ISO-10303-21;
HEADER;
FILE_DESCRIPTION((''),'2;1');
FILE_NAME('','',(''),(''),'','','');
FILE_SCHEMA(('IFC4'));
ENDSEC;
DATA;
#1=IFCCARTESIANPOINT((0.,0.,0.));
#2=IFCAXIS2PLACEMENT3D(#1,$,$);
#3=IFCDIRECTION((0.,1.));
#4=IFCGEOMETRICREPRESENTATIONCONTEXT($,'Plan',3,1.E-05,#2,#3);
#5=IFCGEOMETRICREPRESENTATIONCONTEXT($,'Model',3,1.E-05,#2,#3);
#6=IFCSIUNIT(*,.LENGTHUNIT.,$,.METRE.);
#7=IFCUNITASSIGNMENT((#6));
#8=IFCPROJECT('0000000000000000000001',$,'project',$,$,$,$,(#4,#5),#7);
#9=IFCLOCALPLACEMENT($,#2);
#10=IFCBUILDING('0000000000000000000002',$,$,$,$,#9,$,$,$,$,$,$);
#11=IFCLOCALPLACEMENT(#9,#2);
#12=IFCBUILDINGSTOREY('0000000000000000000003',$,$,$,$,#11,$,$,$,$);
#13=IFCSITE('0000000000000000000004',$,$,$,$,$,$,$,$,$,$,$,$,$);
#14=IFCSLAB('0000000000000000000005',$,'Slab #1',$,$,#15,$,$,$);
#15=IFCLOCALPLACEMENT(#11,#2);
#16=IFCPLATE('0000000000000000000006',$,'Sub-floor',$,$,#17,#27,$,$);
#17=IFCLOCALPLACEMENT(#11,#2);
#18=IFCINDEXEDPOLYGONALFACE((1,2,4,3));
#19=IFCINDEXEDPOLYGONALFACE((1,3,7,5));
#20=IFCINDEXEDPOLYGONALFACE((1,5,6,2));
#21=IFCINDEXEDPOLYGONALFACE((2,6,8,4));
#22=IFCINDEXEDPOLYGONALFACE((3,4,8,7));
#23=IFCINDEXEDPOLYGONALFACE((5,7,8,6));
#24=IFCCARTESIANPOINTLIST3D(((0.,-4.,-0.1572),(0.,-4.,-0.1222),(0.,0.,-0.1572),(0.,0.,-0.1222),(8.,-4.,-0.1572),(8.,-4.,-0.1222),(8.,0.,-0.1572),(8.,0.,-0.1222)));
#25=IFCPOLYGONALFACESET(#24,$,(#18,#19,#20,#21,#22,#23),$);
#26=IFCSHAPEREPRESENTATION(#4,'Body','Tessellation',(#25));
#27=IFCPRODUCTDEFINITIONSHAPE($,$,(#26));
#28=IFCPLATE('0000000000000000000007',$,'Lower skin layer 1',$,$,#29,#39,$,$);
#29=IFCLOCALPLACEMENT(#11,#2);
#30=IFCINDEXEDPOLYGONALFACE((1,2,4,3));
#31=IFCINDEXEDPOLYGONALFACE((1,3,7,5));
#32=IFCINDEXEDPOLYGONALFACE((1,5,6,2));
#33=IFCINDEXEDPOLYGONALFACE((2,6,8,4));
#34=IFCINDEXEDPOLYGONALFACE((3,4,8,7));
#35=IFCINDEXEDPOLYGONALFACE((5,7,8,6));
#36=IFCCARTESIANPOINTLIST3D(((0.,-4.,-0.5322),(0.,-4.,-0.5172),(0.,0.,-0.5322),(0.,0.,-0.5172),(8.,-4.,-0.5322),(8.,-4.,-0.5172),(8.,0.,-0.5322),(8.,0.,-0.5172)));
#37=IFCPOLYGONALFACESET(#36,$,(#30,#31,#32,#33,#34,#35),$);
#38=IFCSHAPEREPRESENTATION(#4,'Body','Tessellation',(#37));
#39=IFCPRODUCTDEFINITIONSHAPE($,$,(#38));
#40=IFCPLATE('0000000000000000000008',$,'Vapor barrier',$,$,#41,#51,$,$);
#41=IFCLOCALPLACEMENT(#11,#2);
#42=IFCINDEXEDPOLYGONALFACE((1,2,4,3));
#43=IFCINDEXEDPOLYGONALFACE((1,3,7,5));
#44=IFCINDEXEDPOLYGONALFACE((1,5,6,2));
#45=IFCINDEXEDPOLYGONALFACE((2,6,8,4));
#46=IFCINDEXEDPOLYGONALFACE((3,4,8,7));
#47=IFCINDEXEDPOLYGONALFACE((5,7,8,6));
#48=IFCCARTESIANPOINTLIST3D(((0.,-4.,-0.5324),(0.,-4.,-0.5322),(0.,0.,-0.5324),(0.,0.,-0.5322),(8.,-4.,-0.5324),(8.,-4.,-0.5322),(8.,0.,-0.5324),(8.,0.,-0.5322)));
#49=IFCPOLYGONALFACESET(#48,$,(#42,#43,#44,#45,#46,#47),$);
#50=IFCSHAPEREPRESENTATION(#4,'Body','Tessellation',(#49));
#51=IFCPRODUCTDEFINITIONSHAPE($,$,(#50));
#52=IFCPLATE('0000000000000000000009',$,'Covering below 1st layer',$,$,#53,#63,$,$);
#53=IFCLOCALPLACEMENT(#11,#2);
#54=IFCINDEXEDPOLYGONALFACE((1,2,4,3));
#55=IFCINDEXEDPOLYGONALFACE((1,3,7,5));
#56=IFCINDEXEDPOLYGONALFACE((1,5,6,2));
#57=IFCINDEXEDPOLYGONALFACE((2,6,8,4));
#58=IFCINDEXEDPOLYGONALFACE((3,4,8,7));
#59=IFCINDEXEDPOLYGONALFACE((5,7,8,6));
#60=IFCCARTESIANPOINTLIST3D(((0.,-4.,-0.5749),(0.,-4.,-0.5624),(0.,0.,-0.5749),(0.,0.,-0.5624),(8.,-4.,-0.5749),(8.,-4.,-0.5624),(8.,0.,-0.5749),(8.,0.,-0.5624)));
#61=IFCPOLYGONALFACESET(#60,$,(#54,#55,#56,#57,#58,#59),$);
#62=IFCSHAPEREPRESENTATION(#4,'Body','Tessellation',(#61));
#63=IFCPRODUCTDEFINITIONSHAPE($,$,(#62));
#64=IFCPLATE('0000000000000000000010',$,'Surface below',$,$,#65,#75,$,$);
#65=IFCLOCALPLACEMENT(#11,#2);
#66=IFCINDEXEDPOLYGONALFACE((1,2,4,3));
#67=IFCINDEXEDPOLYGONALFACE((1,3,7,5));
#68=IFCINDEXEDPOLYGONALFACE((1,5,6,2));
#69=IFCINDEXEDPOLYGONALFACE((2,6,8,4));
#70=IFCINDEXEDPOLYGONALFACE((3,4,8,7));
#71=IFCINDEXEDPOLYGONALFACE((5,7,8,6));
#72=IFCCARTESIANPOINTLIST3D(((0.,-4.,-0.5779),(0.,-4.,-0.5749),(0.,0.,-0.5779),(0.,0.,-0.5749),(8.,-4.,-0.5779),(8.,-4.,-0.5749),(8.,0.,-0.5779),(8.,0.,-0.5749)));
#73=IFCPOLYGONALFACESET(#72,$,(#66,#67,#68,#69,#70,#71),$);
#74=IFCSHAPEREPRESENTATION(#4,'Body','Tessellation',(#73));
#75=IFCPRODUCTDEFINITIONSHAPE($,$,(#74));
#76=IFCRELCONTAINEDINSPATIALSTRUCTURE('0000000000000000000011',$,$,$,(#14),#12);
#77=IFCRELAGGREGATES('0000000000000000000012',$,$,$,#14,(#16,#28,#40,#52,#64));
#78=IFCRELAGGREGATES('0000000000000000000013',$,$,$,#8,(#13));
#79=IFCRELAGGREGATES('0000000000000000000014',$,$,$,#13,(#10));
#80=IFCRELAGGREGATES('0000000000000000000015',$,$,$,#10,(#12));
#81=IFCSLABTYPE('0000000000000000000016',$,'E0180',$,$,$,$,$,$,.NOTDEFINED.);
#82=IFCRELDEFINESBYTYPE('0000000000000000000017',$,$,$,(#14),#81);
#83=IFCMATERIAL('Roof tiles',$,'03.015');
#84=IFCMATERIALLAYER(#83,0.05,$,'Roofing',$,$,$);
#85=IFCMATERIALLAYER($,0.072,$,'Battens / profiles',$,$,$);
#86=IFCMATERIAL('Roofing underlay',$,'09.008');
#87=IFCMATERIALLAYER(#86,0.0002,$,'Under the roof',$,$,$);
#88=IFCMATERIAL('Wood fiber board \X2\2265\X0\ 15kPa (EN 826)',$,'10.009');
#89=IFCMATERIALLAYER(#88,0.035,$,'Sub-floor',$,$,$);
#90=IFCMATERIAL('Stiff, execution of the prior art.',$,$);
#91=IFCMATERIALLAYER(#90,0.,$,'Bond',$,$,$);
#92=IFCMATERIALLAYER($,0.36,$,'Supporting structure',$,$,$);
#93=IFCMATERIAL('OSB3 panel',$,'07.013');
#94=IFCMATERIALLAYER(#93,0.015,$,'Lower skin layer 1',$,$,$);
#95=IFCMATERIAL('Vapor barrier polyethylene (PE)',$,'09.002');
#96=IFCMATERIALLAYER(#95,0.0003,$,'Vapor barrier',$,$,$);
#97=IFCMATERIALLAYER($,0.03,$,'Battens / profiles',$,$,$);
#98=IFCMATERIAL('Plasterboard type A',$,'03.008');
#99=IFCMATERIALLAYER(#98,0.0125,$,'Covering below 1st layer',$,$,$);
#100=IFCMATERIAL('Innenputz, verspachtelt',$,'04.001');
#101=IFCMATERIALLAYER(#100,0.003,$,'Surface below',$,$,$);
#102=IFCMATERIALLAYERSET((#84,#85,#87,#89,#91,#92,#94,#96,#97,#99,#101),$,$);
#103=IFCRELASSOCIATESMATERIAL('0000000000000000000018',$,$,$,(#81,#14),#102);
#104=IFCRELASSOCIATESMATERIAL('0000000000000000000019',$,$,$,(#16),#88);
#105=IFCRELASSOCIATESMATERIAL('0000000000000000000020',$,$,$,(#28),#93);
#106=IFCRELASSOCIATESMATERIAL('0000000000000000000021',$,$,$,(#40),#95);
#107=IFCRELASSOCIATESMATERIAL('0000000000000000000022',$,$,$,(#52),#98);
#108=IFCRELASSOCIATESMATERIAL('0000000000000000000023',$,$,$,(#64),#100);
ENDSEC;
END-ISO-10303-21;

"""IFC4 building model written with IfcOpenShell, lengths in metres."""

from ifc_helpers import new_model, si_unit, direction, frame, frame_2d, origin, place, context, project, spatial, rectangle, extrude, material, layer, layer_set, type_object, element, aggregate, save


model = new_model("IFC4")

# Units and contexts
plan_context = context("Plan", 3, precision=1e-05, world=origin(), true_north=direction((0.0, 1.0)))
model_context = context("Model", 3, precision=1e-05, world=origin(), true_north=direction((0.0, 1.0)))
ifc_project = project(units=[si_unit("LENGTHUNIT", "METRE")], contexts=[plan_context, model_context])

# Site, building, storey
site = spatial("IfcSite", under=ifc_project)
building_placement = place(None, origin())
building = spatial("IfcBuilding", under=site, at=building_placement)
storey_placement = place(building_placement, origin())
storey = spatial("IfcBuildingStorey", under=building, at=storey_placement)

# Slab, plates
ifc_material_1 = material(Name="Roof tiles", Category="03.015")
ifc_layer_1 = layer(ifc_material_1, 0.05, Name="Roofing")
ifc_layer_2 = layer(None, 0.072, Name="Battens / profiles")
ifc_material_2 = material(Name="Roofing underlay", Category="09.008")
ifc_layer_3 = layer(ifc_material_2, 0.0002, Name="Under the roof")
ifc_material_3 = material(Name="Wood fiber board ≥ 15kPa (EN 826)", Category="10.009")
ifc_layer_4 = layer(ifc_material_3, 0.035, Name="Sub-floor")
ifc_material_4 = material(Name="Stiff, execution of the prior art.")
ifc_layer_5 = layer(ifc_material_4, 0.0, Name="Bond")
ifc_layer_6 = layer(None, 0.36, Name="Supporting structure")
ifc_material_5 = material(Name="OSB3 panel", Category="07.013")
ifc_layer_7 = layer(ifc_material_5, 0.015, Name="Lower skin layer 1")
ifc_material_6 = material(Name="Vapor barrier polyethylene (PE)", Category="09.002")
ifc_layer_8 = layer(ifc_material_6, 0.0003, Name="Vapor barrier")
ifc_layer_9 = layer(None, 0.03, Name="Battens / profiles")
ifc_material_7 = material(Name="Plasterboard type A", Category="03.008")
ifc_layer_10 = layer(ifc_material_7, 0.0125, Name="Covering below 1st layer")
ifc_material_8 = material(Name="Innenputz, verspachtelt", Category="04.001")
ifc_layer_11 = layer(ifc_material_8, 0.003, Name="Surface below")
ifc_layer_set = layer_set([ifc_layer_1, ifc_layer_2, ifc_layer_3, ifc_layer_4, ifc_layer_5, ifc_layer_6, ifc_layer_7, ifc_layer_8, ifc_layer_9, ifc_layer_10, ifc_layer_11])
slab_type = type_object("IfcSlabType", Name="E0180", PredefinedType="NOTDEFINED", material=ifc_layer_set)
slab_placement = place(None, frame((0.0, 0.0, 0.0), z_axis=(0.0, 0.0, -1.0), x_axis=(1.0, 0.0, 0.0)))
slab = element("IfcSlab", 1, at=slab_placement, inside=storey, type_object=slab_type, material=ifc_layer_set, Name="Slab #1")
plate_1_placement = place(slab_placement, origin())
plate_1 = element("IfcPlate", 2, at=plate_1_placement, material=ifc_material_3, Name="Sub-floor", context=plan_context, shape_type="SweptSolid", body=[
    extrude(rectangle(XDim=8.0, YDim=4.0, at=frame_2d((4.0, 2.0), x_axis=(1.0, 0.0))), frame((0.0, 0.0, 0.1222), z_axis=(0.0, 0.0, 1.0), x_axis=(1.0, 0.0, 0.0)), (0.0, 0.0, 1.0), 0.035),
])
plate_2_placement = place(slab_placement, origin())
plate_2 = element("IfcPlate", 3, at=plate_2_placement, material=ifc_material_5, Name="Lower skin layer 1", context=plan_context, shape_type="SweptSolid", body=[
    extrude(rectangle(XDim=8.0, YDim=4.0, at=frame_2d((4.0, 2.0), x_axis=(1.0, 0.0))), frame((0.0, 0.0, 0.5172), z_axis=(0.0, 0.0, 1.0), x_axis=(1.0, 0.0, 0.0)), (0.0, 0.0, 1.0), 0.015),
])
plate_3_placement = place(slab_placement, origin())
plate_3 = element("IfcPlate", 4, at=plate_3_placement, material=ifc_material_6, Name="Vapor barrier", context=plan_context, shape_type="SweptSolid", body=[
    extrude(rectangle(XDim=8.0, YDim=4.0, at=frame_2d((4.0, 2.0), x_axis=(1.0, 0.0))), frame((0.0, 0.0, 0.5322), z_axis=(0.0, 0.0, 1.0), x_axis=(1.0, 0.0, 0.0)), (0.0, 0.0, 1.0), 0.0003),
])
plate_4_placement = place(slab_placement, origin())
plate_4 = element("IfcPlate", 5, at=plate_4_placement, material=ifc_material_7, Name="Covering below 1st layer", context=plan_context, shape_type="SweptSolid", body=[
    extrude(rectangle(XDim=8.0, YDim=4.0, at=frame_2d((4.0, 2.0), x_axis=(1.0, 0.0))), frame((0.0, 0.0, 0.5624), z_axis=(0.0, 0.0, 1.0), x_axis=(1.0, 0.0, 0.0)), (0.0, 0.0, 1.0), 0.0125),
])
plate_5_placement = place(slab_placement, origin())
plate_5 = element("IfcPlate", 6, at=plate_5_placement, material=ifc_material_8, Name="Surface below", context=plan_context, shape_type="SweptSolid", body=[
    extrude(rectangle(XDim=8.0, YDim=4.0, at=frame_2d((4.0, 2.0), x_axis=(1.0, 0.0))), frame((0.0, 0.0, 0.5749), z_axis=(0.0, 0.0, 1.0), x_axis=(1.0, 0.0, 0.0)), (0.0, 0.0, 1.0), 0.003),
])
aggregate(slab, [plate_1, plate_2, plate_3, plate_4, plate_5])

save(model, "model.ifc")
